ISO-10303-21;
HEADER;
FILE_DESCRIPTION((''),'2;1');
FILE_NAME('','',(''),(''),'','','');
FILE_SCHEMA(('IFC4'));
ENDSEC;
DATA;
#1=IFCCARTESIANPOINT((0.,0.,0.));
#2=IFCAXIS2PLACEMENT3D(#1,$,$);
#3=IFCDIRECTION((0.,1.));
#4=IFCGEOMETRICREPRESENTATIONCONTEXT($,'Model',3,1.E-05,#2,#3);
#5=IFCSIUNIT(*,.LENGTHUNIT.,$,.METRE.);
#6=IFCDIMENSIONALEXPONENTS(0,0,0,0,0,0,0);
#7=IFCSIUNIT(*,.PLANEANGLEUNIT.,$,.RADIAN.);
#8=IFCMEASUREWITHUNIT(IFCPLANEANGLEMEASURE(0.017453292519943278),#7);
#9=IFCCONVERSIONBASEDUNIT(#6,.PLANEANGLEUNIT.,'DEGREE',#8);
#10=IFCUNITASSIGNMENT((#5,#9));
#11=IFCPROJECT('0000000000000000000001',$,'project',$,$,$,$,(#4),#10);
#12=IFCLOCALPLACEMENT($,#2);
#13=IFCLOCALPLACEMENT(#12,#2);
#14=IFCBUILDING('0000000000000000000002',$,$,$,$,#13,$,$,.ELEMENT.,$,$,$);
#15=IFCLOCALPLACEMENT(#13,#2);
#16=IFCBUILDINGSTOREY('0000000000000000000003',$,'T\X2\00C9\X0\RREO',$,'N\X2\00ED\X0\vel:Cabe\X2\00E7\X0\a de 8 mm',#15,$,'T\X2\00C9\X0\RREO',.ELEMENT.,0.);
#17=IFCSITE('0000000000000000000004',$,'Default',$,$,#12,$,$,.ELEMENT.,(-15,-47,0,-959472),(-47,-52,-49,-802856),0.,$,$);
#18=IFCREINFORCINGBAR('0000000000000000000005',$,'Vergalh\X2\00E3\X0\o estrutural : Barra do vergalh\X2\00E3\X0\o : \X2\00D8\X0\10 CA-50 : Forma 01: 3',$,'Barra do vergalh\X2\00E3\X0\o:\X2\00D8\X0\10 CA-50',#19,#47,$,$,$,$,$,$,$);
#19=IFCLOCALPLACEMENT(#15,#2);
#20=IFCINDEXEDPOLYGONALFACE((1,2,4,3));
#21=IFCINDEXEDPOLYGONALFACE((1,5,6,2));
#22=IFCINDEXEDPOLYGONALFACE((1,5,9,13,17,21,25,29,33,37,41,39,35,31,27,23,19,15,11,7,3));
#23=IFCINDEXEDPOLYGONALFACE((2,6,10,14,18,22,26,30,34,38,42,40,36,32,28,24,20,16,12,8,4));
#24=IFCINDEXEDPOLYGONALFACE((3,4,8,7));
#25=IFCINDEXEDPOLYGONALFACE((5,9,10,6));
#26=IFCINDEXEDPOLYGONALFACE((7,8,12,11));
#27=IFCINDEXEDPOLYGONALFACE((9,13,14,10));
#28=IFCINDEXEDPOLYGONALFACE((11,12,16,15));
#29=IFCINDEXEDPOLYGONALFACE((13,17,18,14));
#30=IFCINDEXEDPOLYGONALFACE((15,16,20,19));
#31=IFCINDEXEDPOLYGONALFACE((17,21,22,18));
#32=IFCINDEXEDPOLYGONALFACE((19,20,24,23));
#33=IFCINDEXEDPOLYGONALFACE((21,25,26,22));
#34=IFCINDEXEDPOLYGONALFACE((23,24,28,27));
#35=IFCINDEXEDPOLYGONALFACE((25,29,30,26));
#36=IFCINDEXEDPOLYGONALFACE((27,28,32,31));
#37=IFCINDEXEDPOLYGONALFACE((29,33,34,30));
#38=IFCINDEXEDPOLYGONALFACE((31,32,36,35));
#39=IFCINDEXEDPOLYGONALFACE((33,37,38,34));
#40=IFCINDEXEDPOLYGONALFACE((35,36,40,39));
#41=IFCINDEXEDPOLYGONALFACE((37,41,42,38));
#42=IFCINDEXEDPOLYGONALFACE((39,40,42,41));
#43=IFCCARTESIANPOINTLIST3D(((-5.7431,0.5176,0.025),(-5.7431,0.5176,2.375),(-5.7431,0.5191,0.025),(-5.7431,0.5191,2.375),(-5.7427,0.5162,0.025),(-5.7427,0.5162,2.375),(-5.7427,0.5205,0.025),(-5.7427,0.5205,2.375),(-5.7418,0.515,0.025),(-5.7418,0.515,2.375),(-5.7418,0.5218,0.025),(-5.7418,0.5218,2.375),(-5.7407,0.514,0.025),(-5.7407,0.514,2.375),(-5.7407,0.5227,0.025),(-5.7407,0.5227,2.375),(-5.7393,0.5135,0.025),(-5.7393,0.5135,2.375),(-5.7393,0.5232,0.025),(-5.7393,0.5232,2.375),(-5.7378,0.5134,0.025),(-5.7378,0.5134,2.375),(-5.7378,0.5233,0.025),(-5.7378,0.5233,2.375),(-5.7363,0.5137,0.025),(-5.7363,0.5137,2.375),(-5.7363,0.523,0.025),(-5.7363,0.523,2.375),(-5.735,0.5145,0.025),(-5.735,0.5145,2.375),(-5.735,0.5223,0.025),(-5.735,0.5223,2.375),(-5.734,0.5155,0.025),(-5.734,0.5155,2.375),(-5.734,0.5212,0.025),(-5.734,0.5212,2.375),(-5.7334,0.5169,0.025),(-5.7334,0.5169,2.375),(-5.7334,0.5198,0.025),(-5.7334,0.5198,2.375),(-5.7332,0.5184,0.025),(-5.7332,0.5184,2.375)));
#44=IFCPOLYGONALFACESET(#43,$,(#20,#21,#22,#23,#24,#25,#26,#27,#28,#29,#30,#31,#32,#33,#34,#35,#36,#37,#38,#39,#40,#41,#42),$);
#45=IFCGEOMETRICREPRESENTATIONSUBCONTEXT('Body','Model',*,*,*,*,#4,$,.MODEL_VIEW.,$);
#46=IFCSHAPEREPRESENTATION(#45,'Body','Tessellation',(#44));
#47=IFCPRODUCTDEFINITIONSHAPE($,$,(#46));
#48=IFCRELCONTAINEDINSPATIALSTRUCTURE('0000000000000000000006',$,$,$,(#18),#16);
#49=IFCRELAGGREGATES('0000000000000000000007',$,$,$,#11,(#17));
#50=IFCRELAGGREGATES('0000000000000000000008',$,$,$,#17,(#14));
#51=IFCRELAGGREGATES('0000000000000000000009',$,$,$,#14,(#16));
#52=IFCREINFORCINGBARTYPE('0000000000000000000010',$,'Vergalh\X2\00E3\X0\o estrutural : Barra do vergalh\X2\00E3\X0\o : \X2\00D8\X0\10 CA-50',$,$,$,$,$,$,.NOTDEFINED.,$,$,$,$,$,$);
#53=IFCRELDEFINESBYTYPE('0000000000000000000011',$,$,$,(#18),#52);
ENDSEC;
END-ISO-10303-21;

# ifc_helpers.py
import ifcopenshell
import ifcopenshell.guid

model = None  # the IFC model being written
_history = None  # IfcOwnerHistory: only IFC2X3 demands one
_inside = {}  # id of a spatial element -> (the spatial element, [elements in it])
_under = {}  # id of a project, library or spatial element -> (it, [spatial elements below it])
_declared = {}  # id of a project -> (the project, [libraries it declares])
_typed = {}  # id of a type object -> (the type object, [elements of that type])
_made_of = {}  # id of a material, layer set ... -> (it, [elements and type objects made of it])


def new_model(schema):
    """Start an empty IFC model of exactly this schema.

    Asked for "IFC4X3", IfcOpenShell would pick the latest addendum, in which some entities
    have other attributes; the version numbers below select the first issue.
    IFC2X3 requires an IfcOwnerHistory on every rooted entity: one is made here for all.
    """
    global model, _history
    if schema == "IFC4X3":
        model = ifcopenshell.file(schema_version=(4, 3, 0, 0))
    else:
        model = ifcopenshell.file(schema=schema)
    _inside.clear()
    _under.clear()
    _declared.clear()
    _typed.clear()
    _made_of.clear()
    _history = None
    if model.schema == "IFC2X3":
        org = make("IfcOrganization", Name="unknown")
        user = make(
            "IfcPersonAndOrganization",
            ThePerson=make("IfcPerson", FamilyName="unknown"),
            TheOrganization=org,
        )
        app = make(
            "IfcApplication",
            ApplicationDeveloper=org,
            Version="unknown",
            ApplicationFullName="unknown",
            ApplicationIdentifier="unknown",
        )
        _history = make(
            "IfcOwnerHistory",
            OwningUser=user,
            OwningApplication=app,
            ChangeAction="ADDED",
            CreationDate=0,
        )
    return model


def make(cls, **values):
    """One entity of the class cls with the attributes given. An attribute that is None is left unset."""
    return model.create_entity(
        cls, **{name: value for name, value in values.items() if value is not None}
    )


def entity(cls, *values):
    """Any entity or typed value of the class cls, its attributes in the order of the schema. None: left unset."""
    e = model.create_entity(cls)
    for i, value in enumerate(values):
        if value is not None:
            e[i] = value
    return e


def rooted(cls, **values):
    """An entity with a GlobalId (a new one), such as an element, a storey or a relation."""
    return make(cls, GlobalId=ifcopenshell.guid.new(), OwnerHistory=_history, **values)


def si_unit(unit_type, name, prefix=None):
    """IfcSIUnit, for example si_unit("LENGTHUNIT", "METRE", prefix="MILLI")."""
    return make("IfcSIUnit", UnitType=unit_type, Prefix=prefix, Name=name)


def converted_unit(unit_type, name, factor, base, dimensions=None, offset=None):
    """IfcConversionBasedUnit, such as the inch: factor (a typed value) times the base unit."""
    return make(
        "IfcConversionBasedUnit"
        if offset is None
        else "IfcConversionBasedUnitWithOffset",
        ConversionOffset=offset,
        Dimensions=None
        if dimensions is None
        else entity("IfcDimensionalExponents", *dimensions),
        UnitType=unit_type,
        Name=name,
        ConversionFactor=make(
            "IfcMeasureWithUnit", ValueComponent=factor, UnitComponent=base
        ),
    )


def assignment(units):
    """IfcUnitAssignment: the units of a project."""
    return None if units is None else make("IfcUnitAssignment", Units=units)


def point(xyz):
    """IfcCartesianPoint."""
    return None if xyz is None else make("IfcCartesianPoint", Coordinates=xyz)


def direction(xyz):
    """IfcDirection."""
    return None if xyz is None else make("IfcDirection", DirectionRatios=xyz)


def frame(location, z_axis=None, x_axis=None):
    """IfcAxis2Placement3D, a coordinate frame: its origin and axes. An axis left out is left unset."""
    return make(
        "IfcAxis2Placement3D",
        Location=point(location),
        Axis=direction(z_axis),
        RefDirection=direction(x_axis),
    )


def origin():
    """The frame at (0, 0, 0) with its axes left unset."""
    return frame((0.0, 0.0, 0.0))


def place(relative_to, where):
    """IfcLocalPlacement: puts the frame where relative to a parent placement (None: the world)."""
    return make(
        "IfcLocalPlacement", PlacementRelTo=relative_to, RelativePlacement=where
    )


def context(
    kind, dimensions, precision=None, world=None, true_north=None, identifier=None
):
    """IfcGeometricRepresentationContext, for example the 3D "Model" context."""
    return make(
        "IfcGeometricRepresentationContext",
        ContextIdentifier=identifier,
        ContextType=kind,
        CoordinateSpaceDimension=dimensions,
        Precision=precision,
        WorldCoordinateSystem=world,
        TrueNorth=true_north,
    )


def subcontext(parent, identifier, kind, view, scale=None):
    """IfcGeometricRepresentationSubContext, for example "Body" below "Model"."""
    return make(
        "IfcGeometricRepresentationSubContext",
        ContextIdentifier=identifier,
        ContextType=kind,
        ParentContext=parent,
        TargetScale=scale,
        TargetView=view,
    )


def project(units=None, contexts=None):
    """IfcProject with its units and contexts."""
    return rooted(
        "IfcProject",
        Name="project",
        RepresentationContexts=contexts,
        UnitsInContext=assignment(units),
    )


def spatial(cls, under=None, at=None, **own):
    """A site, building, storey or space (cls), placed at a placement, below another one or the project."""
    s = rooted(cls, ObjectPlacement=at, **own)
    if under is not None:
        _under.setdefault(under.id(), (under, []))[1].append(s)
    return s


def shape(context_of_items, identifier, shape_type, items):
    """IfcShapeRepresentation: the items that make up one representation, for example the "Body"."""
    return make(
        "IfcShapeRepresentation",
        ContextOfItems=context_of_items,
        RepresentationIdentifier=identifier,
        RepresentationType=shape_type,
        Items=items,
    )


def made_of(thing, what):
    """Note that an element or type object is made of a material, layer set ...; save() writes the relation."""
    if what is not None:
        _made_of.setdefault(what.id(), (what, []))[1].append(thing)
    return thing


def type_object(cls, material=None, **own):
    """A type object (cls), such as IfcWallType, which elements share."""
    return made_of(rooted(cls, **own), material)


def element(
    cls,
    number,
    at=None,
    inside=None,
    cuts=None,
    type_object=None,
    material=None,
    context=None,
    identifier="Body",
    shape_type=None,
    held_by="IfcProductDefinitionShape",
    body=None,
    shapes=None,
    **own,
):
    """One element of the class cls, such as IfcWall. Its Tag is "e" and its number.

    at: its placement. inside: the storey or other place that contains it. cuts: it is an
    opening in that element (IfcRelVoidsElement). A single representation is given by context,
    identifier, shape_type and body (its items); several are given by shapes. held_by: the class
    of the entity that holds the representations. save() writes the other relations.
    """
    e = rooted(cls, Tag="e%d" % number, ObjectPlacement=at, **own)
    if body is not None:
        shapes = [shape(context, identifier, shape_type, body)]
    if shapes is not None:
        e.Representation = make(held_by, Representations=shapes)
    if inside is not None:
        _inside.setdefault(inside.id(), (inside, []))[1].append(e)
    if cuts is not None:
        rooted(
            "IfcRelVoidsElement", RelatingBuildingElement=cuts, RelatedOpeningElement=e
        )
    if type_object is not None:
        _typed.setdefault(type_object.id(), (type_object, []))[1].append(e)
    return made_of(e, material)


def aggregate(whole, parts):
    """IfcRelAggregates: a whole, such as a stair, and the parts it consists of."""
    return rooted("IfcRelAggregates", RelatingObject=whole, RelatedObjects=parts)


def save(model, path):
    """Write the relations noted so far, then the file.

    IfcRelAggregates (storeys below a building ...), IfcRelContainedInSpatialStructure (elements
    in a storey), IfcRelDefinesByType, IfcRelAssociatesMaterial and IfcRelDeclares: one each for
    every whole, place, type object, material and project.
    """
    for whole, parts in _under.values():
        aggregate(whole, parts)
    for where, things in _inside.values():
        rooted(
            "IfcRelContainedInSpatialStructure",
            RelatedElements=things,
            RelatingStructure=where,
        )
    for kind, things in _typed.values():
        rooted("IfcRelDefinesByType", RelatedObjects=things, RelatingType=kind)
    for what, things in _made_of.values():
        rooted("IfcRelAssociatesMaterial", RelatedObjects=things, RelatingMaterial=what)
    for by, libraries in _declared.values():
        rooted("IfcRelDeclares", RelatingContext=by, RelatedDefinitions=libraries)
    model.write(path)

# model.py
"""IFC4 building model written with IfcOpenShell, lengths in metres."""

from ifc_helpers import new_model, entity, si_unit, converted_unit, direction, origin, place, context, subcontext, project, spatial, type_object, element, save


model = new_model("IFC4")

# Units and contexts
model_context = context("Model", 3, precision=1e-05, world=origin(), true_north=direction((0.0, 1.0)))
body_context = subcontext(model_context, "Body", "Model", "MODEL_VIEW")
ifc_project = project(units=[si_unit("LENGTHUNIT", "METRE"), converted_unit("PLANEANGLEUNIT", "DEGREE", entity("IfcPlaneAngleMeasure", 0.017453292519943278), si_unit("PLANEANGLEUNIT", "RADIAN"), dimensions=[0, 0, 0, 0, 0, 0, 0])], contexts=[model_context])

# Site, building, storey
site_placement = place(None, origin())
site = spatial("IfcSite", under=ifc_project, at=site_placement, Name="Default", CompositionType="ELEMENT", RefLatitude=(-15, -47, 0, -959472), RefLongitude=(-47, -52, -49, -802856), RefElevation=0.0)
building_placement = place(site_placement, origin())
building = spatial("IfcBuilding", under=site, at=building_placement, CompositionType="ELEMENT")
storey_placement = place(building_placement, origin())
storey = spatial("IfcBuildingStorey", under=building, at=storey_placement, Name="TÉRREO", ObjectType="Nível:Cabeça de 8 mm", LongName="TÉRREO", CompositionType="ELEMENT", Elevation=0.0)

# Reinforcing bar
reinforcing_bar_type_1 = type_object("IfcReinforcingBarType", Name="Vergalhão estrutural : Barra do vergalhão : Ø10 CA-50", PredefinedType="NOTDEFINED")
reinforcing_bar_1_placement = place(storey_placement, origin())
element("IfcReinforcingBar", 1, at=reinforcing_bar_1_placement, inside=storey, type_object=reinforcing_bar_type_1, Name="Vergalhão estrutural : Barra do vergalhão : Ø10 CA-50 : Forma 01: 3", ObjectType="Barra do vergalhão:Ø10 CA-50", context=body_context, shape_type="AdvancedSweptSolid", body=[
    entity("IfcSweptDiskSolid", entity("IfcIndexedPolyCurve", entity("IfcCartesianPointList3D", [[-5.7382, 0.5184, 0.025], [-5.7382, 0.5184, 2.375]]), None, False), 0.005, None, 0.0, 1.0),
])

save(model, "model.ifc")
